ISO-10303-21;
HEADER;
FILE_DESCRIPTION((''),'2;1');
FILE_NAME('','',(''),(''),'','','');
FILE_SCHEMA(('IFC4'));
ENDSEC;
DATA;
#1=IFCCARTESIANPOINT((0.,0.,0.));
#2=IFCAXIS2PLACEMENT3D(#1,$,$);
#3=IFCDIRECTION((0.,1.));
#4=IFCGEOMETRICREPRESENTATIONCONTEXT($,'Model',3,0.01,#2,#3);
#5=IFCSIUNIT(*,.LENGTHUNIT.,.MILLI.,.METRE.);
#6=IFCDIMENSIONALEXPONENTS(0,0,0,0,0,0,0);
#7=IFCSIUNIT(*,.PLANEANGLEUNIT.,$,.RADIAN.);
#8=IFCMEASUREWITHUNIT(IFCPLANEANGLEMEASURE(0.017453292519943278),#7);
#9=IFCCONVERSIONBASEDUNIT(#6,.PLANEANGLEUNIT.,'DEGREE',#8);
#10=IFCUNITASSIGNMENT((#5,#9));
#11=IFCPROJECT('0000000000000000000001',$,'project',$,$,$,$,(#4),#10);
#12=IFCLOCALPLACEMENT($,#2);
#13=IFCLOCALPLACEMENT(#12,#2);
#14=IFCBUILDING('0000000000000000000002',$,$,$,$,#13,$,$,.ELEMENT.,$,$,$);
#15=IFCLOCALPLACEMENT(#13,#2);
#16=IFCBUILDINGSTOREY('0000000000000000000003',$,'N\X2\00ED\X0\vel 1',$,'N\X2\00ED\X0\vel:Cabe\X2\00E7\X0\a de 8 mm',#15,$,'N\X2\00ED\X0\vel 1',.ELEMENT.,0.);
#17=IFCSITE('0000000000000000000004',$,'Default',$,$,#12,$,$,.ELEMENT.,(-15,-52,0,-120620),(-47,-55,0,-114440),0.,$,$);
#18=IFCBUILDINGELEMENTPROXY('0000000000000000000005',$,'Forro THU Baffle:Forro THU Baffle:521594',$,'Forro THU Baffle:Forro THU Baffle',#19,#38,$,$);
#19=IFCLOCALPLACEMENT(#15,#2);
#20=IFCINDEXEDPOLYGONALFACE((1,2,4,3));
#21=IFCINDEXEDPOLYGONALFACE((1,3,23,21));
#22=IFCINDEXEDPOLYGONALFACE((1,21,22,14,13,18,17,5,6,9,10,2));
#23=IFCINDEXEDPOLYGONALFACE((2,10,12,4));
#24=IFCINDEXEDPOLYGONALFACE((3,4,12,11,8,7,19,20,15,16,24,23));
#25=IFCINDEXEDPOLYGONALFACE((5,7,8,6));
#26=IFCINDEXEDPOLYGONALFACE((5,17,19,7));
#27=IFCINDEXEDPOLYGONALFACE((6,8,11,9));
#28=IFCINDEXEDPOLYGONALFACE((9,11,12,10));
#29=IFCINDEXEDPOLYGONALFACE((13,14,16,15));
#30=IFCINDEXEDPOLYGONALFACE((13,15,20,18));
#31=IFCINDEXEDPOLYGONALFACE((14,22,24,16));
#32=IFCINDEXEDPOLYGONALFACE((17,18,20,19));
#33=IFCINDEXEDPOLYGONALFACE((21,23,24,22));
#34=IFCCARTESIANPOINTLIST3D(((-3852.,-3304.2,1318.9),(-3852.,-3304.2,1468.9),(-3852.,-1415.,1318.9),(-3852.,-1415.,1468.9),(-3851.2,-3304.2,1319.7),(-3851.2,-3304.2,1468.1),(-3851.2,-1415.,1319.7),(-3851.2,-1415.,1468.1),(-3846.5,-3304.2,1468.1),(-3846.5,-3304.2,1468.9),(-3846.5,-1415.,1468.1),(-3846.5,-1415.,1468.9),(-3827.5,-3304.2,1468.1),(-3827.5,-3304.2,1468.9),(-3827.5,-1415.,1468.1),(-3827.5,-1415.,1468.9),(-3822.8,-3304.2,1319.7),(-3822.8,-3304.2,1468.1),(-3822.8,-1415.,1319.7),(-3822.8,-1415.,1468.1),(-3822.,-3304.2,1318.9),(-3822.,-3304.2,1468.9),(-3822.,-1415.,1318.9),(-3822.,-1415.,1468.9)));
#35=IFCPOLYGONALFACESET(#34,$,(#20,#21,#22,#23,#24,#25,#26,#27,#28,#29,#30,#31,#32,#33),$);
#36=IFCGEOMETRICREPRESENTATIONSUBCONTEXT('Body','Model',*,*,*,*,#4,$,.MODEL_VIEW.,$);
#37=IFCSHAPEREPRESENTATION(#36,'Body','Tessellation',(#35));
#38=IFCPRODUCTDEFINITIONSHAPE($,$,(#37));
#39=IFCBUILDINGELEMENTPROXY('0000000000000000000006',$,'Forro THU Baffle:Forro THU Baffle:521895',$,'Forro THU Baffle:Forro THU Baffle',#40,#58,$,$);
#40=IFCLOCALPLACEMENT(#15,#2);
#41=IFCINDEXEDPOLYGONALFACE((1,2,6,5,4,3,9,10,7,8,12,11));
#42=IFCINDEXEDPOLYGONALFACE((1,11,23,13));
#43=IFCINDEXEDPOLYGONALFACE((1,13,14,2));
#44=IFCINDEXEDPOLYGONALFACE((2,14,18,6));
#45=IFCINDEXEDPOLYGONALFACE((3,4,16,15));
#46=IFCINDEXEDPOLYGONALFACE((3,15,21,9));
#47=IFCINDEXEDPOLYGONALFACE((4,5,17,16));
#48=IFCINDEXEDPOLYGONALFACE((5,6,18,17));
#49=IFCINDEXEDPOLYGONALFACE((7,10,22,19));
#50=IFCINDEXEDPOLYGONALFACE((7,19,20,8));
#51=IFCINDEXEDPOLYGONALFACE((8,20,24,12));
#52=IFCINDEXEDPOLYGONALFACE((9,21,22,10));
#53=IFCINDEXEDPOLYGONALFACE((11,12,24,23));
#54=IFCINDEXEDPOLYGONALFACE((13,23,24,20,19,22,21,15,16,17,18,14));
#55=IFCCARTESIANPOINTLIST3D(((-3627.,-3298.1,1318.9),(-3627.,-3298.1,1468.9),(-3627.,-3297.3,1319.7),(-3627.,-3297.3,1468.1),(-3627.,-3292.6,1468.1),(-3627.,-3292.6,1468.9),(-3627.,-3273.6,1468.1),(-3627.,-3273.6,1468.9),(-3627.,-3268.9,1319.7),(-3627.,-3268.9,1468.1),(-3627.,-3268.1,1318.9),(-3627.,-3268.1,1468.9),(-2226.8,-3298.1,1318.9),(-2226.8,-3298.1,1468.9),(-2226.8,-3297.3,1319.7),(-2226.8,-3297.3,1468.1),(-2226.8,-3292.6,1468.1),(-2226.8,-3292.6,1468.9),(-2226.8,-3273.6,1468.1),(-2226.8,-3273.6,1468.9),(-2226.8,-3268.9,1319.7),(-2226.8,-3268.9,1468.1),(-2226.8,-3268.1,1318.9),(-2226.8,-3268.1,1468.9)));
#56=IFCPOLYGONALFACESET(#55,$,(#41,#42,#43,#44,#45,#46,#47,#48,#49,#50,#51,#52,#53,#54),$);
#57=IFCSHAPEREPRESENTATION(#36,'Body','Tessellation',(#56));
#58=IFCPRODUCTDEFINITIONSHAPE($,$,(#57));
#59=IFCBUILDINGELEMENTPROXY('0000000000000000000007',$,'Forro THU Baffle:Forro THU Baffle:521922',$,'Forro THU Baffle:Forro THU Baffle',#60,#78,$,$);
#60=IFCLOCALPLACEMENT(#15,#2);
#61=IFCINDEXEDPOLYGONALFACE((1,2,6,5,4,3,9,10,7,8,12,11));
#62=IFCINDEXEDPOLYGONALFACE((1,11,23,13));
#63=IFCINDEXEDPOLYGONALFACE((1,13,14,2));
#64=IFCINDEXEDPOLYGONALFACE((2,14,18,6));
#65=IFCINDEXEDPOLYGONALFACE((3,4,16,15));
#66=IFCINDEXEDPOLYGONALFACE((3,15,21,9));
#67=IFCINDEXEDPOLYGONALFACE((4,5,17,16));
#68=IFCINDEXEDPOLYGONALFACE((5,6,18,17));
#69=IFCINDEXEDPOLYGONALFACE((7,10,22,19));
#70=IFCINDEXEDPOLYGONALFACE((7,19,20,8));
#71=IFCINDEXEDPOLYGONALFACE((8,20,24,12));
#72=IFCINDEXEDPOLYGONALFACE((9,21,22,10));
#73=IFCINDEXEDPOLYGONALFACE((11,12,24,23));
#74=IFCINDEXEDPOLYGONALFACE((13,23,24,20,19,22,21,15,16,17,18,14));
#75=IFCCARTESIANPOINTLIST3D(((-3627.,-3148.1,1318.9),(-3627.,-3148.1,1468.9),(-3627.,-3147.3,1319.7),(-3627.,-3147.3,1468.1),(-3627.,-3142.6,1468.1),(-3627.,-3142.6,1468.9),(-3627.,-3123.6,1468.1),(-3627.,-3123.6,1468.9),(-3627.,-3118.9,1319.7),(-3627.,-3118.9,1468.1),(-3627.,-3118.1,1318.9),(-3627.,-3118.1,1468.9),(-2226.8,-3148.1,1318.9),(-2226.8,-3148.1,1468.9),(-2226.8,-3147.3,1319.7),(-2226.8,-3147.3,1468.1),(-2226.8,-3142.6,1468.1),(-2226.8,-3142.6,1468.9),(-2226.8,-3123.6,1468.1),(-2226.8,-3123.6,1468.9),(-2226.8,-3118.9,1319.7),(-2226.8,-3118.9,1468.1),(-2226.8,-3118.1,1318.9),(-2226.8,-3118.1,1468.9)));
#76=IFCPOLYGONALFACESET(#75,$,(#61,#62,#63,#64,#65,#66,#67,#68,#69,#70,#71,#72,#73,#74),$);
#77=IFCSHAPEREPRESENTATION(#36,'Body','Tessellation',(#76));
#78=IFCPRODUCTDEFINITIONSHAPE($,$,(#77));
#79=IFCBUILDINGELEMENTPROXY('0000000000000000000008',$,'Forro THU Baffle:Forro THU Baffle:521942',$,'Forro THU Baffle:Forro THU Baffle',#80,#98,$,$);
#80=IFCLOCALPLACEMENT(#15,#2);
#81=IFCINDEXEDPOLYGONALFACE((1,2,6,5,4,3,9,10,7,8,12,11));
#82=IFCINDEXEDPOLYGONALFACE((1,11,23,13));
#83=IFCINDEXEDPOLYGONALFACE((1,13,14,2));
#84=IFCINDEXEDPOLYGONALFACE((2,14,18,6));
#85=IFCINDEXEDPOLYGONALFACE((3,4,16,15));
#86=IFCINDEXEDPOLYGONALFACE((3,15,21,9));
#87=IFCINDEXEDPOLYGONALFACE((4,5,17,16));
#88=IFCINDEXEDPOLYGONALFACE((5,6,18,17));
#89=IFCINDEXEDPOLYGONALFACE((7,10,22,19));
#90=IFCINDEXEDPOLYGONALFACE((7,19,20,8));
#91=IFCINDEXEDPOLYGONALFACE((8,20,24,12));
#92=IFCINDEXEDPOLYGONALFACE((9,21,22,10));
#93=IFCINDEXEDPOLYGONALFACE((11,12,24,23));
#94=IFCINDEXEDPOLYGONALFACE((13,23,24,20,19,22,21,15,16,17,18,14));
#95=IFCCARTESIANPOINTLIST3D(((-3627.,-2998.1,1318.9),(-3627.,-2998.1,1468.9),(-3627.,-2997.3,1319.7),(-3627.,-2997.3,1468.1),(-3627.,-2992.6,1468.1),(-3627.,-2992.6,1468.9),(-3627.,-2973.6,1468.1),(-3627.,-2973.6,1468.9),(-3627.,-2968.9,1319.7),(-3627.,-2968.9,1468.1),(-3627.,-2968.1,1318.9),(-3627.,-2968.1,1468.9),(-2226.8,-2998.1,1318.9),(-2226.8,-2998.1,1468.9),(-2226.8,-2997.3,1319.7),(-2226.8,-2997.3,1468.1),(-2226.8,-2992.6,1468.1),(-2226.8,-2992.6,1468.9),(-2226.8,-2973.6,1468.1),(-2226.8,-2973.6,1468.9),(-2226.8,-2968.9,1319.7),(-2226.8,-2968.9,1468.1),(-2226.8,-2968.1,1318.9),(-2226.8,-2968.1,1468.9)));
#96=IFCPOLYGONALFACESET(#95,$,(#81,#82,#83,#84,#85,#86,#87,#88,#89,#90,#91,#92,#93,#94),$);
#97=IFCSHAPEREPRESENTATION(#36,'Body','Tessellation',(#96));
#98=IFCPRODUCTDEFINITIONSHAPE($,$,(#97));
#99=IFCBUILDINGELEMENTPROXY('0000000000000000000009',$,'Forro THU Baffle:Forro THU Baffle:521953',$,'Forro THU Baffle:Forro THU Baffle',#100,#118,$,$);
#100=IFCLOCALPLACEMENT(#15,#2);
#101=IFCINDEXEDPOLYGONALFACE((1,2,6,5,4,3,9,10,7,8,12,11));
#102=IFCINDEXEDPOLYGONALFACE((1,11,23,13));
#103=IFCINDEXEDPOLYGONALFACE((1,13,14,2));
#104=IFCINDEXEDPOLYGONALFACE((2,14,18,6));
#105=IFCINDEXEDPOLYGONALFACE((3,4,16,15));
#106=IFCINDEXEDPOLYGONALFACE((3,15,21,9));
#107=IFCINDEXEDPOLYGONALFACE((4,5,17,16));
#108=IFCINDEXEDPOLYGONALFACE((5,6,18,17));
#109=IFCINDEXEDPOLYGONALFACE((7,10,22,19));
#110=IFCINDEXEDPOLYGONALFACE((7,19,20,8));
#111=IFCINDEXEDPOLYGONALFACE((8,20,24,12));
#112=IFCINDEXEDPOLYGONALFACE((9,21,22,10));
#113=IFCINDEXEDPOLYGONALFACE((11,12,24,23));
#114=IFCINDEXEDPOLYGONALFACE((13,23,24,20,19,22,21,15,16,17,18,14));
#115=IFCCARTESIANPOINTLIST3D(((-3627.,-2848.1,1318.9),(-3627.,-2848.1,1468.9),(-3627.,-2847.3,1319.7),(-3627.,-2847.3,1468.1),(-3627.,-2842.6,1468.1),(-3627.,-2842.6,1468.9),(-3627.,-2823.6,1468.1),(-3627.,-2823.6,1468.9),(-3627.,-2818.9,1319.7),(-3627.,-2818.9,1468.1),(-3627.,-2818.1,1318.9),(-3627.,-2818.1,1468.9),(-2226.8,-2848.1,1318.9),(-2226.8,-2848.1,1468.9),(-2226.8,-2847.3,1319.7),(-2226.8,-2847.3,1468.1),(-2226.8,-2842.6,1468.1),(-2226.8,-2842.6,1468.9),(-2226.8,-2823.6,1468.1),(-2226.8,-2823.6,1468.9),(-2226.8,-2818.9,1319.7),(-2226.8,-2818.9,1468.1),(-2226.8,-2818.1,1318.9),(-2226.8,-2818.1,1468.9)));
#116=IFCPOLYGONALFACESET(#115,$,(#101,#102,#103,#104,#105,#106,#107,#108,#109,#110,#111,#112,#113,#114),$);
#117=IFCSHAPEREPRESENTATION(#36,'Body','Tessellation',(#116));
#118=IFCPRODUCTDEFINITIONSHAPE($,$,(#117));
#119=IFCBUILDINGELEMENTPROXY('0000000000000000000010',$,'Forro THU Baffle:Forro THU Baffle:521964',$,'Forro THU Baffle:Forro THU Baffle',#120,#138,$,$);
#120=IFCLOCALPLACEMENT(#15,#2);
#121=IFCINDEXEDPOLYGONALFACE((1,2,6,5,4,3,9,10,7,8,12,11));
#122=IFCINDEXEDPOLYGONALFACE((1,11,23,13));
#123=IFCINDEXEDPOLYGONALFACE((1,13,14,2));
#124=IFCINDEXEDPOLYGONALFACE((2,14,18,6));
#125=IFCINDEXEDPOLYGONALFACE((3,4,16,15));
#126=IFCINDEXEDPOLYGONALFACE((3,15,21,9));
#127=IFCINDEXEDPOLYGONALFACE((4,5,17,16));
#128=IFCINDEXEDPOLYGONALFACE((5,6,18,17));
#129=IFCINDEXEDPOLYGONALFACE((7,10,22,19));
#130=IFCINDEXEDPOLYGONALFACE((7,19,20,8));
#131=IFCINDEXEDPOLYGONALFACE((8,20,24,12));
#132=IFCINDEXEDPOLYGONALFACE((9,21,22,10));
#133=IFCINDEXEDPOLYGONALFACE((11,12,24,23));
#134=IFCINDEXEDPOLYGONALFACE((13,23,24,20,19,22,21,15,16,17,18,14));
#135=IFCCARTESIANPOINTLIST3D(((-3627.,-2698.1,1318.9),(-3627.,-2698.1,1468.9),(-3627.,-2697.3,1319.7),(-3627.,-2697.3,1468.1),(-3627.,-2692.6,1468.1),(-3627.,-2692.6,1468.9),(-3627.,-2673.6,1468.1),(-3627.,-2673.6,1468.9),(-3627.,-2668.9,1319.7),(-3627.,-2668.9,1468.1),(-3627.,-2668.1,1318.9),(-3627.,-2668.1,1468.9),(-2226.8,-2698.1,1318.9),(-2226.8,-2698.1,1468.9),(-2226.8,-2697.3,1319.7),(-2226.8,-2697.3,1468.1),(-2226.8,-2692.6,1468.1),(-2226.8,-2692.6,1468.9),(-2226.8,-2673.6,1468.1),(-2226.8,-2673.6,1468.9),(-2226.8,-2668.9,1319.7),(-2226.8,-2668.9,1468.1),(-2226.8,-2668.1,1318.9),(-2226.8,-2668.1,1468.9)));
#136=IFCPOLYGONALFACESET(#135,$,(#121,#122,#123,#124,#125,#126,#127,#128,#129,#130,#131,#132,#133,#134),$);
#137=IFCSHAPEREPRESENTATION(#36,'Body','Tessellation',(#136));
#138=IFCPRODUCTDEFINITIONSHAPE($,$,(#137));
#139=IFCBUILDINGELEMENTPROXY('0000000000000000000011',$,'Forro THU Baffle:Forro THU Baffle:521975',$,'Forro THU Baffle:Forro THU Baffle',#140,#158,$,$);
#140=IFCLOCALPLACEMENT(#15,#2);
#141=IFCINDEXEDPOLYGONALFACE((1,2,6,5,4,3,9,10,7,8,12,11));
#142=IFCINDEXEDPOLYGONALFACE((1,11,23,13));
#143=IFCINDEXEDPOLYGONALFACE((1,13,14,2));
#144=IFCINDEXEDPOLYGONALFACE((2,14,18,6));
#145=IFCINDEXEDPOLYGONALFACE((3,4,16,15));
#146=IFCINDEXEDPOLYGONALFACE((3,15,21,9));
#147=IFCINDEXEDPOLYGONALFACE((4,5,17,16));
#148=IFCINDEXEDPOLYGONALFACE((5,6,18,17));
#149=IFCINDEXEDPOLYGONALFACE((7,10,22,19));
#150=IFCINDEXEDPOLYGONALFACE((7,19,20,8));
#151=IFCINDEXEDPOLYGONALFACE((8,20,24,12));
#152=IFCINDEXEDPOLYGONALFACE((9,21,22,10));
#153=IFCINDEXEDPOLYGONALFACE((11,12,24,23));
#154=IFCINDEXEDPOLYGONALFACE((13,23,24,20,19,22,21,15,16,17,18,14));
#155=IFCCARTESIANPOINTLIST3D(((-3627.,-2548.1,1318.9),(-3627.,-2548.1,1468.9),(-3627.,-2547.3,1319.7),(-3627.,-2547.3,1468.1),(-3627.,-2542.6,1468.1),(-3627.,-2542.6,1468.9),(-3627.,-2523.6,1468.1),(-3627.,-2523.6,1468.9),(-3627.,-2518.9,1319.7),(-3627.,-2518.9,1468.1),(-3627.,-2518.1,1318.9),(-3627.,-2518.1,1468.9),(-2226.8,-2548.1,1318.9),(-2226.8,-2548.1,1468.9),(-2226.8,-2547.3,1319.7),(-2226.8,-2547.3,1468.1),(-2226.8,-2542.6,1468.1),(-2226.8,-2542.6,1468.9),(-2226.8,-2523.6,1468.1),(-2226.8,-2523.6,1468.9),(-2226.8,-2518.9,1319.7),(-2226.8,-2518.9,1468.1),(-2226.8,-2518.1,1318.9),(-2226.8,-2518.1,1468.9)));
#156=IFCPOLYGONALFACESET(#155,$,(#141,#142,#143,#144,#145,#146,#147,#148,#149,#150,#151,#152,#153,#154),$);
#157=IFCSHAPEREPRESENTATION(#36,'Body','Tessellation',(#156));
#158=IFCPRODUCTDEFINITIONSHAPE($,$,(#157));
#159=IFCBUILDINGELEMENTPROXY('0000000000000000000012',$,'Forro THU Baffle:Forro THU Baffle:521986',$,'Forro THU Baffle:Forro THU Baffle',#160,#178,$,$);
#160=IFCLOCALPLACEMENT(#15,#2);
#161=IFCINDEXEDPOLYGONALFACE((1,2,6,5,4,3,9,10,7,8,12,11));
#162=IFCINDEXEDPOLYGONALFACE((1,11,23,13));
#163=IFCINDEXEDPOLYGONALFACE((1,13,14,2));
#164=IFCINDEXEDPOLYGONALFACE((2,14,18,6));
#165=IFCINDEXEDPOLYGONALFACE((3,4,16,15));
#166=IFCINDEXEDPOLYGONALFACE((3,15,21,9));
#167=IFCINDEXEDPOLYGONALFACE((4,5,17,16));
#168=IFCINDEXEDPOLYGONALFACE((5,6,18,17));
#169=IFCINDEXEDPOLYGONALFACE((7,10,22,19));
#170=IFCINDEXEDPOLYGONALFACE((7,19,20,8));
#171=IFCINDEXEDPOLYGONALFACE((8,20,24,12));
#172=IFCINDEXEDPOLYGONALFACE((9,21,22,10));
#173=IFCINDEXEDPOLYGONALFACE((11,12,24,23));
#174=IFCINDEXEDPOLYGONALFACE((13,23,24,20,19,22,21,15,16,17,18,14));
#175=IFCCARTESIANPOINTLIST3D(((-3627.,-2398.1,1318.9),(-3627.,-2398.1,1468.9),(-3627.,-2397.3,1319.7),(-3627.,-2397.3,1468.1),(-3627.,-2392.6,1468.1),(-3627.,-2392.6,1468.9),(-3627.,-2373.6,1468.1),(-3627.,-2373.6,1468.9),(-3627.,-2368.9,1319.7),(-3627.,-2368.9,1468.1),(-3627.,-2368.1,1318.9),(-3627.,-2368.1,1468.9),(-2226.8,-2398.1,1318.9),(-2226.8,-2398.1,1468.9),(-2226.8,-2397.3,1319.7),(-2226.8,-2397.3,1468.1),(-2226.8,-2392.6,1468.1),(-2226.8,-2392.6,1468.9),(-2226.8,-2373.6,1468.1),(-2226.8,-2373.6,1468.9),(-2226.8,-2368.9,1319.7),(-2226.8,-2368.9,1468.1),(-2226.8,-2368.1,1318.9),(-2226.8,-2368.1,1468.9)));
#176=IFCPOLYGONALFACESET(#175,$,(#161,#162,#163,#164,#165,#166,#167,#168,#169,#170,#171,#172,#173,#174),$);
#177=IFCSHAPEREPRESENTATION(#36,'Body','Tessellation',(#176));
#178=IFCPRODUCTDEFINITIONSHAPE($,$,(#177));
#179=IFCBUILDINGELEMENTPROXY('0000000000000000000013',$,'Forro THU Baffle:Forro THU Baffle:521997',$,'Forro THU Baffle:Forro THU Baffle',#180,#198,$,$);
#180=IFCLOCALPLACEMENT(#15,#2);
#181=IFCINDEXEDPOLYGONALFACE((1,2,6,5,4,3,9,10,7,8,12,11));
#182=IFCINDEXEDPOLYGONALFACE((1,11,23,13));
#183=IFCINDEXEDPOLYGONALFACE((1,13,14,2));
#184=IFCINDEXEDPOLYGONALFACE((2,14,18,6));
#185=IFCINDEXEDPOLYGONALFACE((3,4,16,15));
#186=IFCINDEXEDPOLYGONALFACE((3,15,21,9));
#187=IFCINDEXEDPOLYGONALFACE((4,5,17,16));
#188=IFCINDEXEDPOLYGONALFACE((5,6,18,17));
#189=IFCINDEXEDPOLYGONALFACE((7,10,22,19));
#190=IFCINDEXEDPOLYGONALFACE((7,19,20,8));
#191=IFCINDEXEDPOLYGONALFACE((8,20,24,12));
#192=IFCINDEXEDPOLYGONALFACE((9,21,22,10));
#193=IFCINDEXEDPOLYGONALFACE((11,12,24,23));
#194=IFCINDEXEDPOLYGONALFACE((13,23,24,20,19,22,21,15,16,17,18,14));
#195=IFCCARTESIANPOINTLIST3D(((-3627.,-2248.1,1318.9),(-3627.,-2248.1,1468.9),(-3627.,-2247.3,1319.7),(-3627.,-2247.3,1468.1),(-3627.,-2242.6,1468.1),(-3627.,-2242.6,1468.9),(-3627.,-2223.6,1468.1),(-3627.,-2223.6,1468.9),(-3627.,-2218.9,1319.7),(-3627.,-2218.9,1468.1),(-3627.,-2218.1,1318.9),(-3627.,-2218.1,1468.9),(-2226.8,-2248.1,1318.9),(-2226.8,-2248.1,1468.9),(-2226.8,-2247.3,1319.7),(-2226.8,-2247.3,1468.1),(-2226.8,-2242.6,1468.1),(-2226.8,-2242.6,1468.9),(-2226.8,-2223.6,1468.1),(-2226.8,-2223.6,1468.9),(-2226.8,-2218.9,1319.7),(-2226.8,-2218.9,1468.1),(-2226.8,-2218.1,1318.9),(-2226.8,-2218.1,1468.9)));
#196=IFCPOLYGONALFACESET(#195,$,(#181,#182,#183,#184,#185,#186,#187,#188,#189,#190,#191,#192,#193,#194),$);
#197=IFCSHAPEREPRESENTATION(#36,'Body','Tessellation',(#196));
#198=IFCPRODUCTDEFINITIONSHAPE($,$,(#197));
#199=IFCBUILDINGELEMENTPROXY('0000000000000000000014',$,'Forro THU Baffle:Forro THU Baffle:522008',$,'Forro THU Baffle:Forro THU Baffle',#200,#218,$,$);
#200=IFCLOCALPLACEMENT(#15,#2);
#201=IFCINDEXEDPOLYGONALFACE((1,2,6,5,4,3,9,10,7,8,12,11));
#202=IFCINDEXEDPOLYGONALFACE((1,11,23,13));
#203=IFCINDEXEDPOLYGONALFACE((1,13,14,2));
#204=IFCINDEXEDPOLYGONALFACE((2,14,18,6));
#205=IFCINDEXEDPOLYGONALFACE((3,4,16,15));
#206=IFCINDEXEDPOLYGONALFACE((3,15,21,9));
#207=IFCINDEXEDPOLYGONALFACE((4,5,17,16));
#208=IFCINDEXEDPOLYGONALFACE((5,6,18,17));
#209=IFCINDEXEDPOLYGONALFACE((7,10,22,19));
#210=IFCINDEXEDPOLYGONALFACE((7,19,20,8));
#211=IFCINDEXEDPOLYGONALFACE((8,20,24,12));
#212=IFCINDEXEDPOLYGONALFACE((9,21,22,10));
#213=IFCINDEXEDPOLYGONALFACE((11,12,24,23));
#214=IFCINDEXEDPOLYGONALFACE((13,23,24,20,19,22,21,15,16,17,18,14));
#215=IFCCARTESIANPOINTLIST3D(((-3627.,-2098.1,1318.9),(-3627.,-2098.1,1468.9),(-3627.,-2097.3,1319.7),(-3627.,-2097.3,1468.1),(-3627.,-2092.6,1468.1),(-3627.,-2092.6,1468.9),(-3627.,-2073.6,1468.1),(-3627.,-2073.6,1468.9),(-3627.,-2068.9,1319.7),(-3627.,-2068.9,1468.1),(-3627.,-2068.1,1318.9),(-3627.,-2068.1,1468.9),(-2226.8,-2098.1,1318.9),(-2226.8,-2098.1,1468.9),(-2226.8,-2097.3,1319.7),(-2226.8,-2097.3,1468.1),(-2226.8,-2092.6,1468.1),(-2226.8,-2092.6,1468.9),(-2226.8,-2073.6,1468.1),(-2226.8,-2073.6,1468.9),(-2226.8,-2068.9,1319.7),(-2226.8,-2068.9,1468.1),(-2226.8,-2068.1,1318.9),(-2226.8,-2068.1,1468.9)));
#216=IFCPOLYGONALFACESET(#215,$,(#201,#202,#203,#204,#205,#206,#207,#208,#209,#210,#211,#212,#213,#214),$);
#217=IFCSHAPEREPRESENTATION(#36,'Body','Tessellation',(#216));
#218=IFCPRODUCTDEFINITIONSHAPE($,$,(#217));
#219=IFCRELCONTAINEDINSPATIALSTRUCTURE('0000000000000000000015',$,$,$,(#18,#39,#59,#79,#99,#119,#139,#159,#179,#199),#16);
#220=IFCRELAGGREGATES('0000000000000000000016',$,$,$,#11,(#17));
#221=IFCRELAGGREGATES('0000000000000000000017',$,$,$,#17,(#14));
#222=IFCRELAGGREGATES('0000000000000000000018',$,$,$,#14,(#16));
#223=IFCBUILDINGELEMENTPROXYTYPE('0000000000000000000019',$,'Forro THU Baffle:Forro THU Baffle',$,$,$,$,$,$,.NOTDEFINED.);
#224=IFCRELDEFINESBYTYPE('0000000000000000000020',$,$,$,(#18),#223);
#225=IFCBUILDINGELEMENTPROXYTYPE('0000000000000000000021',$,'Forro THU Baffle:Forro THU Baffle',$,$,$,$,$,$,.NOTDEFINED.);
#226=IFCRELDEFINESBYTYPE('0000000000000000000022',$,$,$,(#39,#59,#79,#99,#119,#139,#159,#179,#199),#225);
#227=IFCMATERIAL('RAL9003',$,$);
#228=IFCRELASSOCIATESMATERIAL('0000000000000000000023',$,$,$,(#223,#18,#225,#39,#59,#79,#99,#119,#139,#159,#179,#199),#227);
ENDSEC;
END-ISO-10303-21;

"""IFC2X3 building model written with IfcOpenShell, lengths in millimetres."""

from ifc_helpers import new_model, entity, si_unit, converted_unit, direction, frame, origin, place, context, subcontext, project, spatial, polyline, outline, extrude, source, transform, mapped, material, type_object, type_shapes, element, save


model = new_model("IFC2X3")

# Units and contexts
model_context = context("Model", 3, precision=0.01, world=origin(), true_north=direction((0.0, 1.0)))
body_context = subcontext(model_context, "Body", "Model", "MODEL_VIEW")
ifc_project = project(units=[si_unit("LENGTHUNIT", "METRE", prefix="MILLI"), converted_unit("PLANEANGLEUNIT", "DEGREE", entity("IfcPlaneAngleMeasure", 0.017453292519943278), si_unit("PLANEANGLEUNIT", "RADIAN"), dimensions=[0, 0, 0, 0, 0, 0, 0])], contexts=[model_context])

# Site, building, storey
site_placement = place(None, origin())
site = spatial("IfcSite", under=ifc_project, at=site_placement, Name="Default", CompositionType="ELEMENT", RefLatitude=(-15, -52, 0, -120620), RefLongitude=(-47, -55, 0, -114440), RefElevation=0.0)
building_placement = place(site_placement, origin())
building = spatial("IfcBuilding", under=site, at=building_placement, CompositionType="ELEMENT")
storey_placement = place(building_placement, origin())
storey = spatial("IfcBuildingStorey", under=building, at=storey_placement, Name="Nível 1", ObjectType="Nível:Cabeça de 8 mm", LongName="Nível 1", CompositionType="ELEMENT", Elevation=0.0)

# Building element proxies
ifc_material = material(Name="RAL9003")
building_element_proxy_type_1 = type_object("IfcBuildingElementProxyType", Name="Forro THU Baffle:Forro THU Baffle", PredefinedType="NOTDEFINED", material=ifc_material)
shared_shape_1 = source(origin(), body_context, "Body", "SweptSolid", [
    extrude(outline(polyline([(-99.9, -15.0), (50.1, -15.0), (50.1, -9.5), (49.3, -9.5), (49.3, -14.2), (-99.1, -14.2), (-99.1, 14.2), (49.3, 14.2), (49.3, 9.5), (50.1, 9.5), (50.1, 15.0), (-99.9, 15.0), (-99.9, -15.0)])), frame((0.0, -15.0, -50.1), z_axis=(1.0, 0.0, 0.0), x_axis=(0.0, 0.0, 1.0)), (0.0, 0.0, 1.0), 1889.2),
])
type_shapes(building_element_proxy_type_1, [shared_shape_1])
proxy_1_placement = place(storey_placement, frame((-3852.0, -3304.2, 1468.9), z_axis=(0.0, 0.0, 1.0), x_axis=(0.0, 1.0, 0.0)))
element("IfcBuildingElementProxy", 1, at=proxy_1_placement, inside=storey, type_object=building_element_proxy_type_1, material=ifc_material, Name="Forro THU Baffle:Forro THU Baffle:521594", ObjectType="Forro THU Baffle:Forro THU Baffle", context=body_context, shape_type="MappedRepresentation", body=[
    mapped(shared_shape_1, transform((0.0, 0.0, 0.0), scale=1.0)),
])
building_element_proxy_type_2 = type_object("IfcBuildingElementProxyType", Name="Forro THU Baffle:Forro THU Baffle", PredefinedType="NOTDEFINED", material=ifc_material)
shared_shape_2 = source(origin(), body_context, "Body", "SweptSolid", [
    extrude(outline(polyline([(-15.0, -99.9), (15.0, -99.9), (15.0, 50.1), (9.5, 50.1), (9.5, 49.3), (14.2, 49.3), (14.2, -99.1), (-14.2, -99.1), (-14.2, 49.3), (-9.5, 49.3), (-9.5, 50.1), (-15.0, 50.1), (-15.0, -99.9)])), frame((0.0, 15.0, -50.1), z_axis=(1.0, 0.0, 0.0), x_axis=(0.0, 1.0, 0.0)), (0.0, 0.0, 1.0), 1400.1),
])
type_shapes(building_element_proxy_type_2, [shared_shape_2])
for number, where, name in (
    (2, (-3627.0, -3298.1, 1468.9), "Forro THU Baffle:Forro THU Baffle:521895"),
    (3, (-3627.0, -3148.1, 1468.9), "Forro THU Baffle:Forro THU Baffle:521922"),
    (4, (-3627.0, -2998.1, 1468.9), "Forro THU Baffle:Forro THU Baffle:521942"),
    (5, (-3627.0, -2848.1, 1468.9), "Forro THU Baffle:Forro THU Baffle:521953"),
    (6, (-3627.0, -2698.1, 1468.9), "Forro THU Baffle:Forro THU Baffle:521964"),
    (7, (-3627.0, -2548.1, 1468.9), "Forro THU Baffle:Forro THU Baffle:521975"),
    (8, (-3627.0, -2398.1, 1468.9), "Forro THU Baffle:Forro THU Baffle:521986"),
    (9, (-3627.0, -2248.1, 1468.9), "Forro THU Baffle:Forro THU Baffle:521997"),
    (10, (-3627.0, -2098.1, 1468.9), "Forro THU Baffle:Forro THU Baffle:522008"),
):
    element("IfcBuildingElementProxy", number, at=place(storey_placement, frame(where)), inside=storey, type_object=building_element_proxy_type_2, material=ifc_material, Name=name, ObjectType="Forro THU Baffle:Forro THU Baffle", context=body_context, shape_type="MappedRepresentation", body=[
        mapped(shared_shape_2, transform((0.0, 0.0, 0.0), scale=1.0)),
    ])

save(model, "model.ifc")
